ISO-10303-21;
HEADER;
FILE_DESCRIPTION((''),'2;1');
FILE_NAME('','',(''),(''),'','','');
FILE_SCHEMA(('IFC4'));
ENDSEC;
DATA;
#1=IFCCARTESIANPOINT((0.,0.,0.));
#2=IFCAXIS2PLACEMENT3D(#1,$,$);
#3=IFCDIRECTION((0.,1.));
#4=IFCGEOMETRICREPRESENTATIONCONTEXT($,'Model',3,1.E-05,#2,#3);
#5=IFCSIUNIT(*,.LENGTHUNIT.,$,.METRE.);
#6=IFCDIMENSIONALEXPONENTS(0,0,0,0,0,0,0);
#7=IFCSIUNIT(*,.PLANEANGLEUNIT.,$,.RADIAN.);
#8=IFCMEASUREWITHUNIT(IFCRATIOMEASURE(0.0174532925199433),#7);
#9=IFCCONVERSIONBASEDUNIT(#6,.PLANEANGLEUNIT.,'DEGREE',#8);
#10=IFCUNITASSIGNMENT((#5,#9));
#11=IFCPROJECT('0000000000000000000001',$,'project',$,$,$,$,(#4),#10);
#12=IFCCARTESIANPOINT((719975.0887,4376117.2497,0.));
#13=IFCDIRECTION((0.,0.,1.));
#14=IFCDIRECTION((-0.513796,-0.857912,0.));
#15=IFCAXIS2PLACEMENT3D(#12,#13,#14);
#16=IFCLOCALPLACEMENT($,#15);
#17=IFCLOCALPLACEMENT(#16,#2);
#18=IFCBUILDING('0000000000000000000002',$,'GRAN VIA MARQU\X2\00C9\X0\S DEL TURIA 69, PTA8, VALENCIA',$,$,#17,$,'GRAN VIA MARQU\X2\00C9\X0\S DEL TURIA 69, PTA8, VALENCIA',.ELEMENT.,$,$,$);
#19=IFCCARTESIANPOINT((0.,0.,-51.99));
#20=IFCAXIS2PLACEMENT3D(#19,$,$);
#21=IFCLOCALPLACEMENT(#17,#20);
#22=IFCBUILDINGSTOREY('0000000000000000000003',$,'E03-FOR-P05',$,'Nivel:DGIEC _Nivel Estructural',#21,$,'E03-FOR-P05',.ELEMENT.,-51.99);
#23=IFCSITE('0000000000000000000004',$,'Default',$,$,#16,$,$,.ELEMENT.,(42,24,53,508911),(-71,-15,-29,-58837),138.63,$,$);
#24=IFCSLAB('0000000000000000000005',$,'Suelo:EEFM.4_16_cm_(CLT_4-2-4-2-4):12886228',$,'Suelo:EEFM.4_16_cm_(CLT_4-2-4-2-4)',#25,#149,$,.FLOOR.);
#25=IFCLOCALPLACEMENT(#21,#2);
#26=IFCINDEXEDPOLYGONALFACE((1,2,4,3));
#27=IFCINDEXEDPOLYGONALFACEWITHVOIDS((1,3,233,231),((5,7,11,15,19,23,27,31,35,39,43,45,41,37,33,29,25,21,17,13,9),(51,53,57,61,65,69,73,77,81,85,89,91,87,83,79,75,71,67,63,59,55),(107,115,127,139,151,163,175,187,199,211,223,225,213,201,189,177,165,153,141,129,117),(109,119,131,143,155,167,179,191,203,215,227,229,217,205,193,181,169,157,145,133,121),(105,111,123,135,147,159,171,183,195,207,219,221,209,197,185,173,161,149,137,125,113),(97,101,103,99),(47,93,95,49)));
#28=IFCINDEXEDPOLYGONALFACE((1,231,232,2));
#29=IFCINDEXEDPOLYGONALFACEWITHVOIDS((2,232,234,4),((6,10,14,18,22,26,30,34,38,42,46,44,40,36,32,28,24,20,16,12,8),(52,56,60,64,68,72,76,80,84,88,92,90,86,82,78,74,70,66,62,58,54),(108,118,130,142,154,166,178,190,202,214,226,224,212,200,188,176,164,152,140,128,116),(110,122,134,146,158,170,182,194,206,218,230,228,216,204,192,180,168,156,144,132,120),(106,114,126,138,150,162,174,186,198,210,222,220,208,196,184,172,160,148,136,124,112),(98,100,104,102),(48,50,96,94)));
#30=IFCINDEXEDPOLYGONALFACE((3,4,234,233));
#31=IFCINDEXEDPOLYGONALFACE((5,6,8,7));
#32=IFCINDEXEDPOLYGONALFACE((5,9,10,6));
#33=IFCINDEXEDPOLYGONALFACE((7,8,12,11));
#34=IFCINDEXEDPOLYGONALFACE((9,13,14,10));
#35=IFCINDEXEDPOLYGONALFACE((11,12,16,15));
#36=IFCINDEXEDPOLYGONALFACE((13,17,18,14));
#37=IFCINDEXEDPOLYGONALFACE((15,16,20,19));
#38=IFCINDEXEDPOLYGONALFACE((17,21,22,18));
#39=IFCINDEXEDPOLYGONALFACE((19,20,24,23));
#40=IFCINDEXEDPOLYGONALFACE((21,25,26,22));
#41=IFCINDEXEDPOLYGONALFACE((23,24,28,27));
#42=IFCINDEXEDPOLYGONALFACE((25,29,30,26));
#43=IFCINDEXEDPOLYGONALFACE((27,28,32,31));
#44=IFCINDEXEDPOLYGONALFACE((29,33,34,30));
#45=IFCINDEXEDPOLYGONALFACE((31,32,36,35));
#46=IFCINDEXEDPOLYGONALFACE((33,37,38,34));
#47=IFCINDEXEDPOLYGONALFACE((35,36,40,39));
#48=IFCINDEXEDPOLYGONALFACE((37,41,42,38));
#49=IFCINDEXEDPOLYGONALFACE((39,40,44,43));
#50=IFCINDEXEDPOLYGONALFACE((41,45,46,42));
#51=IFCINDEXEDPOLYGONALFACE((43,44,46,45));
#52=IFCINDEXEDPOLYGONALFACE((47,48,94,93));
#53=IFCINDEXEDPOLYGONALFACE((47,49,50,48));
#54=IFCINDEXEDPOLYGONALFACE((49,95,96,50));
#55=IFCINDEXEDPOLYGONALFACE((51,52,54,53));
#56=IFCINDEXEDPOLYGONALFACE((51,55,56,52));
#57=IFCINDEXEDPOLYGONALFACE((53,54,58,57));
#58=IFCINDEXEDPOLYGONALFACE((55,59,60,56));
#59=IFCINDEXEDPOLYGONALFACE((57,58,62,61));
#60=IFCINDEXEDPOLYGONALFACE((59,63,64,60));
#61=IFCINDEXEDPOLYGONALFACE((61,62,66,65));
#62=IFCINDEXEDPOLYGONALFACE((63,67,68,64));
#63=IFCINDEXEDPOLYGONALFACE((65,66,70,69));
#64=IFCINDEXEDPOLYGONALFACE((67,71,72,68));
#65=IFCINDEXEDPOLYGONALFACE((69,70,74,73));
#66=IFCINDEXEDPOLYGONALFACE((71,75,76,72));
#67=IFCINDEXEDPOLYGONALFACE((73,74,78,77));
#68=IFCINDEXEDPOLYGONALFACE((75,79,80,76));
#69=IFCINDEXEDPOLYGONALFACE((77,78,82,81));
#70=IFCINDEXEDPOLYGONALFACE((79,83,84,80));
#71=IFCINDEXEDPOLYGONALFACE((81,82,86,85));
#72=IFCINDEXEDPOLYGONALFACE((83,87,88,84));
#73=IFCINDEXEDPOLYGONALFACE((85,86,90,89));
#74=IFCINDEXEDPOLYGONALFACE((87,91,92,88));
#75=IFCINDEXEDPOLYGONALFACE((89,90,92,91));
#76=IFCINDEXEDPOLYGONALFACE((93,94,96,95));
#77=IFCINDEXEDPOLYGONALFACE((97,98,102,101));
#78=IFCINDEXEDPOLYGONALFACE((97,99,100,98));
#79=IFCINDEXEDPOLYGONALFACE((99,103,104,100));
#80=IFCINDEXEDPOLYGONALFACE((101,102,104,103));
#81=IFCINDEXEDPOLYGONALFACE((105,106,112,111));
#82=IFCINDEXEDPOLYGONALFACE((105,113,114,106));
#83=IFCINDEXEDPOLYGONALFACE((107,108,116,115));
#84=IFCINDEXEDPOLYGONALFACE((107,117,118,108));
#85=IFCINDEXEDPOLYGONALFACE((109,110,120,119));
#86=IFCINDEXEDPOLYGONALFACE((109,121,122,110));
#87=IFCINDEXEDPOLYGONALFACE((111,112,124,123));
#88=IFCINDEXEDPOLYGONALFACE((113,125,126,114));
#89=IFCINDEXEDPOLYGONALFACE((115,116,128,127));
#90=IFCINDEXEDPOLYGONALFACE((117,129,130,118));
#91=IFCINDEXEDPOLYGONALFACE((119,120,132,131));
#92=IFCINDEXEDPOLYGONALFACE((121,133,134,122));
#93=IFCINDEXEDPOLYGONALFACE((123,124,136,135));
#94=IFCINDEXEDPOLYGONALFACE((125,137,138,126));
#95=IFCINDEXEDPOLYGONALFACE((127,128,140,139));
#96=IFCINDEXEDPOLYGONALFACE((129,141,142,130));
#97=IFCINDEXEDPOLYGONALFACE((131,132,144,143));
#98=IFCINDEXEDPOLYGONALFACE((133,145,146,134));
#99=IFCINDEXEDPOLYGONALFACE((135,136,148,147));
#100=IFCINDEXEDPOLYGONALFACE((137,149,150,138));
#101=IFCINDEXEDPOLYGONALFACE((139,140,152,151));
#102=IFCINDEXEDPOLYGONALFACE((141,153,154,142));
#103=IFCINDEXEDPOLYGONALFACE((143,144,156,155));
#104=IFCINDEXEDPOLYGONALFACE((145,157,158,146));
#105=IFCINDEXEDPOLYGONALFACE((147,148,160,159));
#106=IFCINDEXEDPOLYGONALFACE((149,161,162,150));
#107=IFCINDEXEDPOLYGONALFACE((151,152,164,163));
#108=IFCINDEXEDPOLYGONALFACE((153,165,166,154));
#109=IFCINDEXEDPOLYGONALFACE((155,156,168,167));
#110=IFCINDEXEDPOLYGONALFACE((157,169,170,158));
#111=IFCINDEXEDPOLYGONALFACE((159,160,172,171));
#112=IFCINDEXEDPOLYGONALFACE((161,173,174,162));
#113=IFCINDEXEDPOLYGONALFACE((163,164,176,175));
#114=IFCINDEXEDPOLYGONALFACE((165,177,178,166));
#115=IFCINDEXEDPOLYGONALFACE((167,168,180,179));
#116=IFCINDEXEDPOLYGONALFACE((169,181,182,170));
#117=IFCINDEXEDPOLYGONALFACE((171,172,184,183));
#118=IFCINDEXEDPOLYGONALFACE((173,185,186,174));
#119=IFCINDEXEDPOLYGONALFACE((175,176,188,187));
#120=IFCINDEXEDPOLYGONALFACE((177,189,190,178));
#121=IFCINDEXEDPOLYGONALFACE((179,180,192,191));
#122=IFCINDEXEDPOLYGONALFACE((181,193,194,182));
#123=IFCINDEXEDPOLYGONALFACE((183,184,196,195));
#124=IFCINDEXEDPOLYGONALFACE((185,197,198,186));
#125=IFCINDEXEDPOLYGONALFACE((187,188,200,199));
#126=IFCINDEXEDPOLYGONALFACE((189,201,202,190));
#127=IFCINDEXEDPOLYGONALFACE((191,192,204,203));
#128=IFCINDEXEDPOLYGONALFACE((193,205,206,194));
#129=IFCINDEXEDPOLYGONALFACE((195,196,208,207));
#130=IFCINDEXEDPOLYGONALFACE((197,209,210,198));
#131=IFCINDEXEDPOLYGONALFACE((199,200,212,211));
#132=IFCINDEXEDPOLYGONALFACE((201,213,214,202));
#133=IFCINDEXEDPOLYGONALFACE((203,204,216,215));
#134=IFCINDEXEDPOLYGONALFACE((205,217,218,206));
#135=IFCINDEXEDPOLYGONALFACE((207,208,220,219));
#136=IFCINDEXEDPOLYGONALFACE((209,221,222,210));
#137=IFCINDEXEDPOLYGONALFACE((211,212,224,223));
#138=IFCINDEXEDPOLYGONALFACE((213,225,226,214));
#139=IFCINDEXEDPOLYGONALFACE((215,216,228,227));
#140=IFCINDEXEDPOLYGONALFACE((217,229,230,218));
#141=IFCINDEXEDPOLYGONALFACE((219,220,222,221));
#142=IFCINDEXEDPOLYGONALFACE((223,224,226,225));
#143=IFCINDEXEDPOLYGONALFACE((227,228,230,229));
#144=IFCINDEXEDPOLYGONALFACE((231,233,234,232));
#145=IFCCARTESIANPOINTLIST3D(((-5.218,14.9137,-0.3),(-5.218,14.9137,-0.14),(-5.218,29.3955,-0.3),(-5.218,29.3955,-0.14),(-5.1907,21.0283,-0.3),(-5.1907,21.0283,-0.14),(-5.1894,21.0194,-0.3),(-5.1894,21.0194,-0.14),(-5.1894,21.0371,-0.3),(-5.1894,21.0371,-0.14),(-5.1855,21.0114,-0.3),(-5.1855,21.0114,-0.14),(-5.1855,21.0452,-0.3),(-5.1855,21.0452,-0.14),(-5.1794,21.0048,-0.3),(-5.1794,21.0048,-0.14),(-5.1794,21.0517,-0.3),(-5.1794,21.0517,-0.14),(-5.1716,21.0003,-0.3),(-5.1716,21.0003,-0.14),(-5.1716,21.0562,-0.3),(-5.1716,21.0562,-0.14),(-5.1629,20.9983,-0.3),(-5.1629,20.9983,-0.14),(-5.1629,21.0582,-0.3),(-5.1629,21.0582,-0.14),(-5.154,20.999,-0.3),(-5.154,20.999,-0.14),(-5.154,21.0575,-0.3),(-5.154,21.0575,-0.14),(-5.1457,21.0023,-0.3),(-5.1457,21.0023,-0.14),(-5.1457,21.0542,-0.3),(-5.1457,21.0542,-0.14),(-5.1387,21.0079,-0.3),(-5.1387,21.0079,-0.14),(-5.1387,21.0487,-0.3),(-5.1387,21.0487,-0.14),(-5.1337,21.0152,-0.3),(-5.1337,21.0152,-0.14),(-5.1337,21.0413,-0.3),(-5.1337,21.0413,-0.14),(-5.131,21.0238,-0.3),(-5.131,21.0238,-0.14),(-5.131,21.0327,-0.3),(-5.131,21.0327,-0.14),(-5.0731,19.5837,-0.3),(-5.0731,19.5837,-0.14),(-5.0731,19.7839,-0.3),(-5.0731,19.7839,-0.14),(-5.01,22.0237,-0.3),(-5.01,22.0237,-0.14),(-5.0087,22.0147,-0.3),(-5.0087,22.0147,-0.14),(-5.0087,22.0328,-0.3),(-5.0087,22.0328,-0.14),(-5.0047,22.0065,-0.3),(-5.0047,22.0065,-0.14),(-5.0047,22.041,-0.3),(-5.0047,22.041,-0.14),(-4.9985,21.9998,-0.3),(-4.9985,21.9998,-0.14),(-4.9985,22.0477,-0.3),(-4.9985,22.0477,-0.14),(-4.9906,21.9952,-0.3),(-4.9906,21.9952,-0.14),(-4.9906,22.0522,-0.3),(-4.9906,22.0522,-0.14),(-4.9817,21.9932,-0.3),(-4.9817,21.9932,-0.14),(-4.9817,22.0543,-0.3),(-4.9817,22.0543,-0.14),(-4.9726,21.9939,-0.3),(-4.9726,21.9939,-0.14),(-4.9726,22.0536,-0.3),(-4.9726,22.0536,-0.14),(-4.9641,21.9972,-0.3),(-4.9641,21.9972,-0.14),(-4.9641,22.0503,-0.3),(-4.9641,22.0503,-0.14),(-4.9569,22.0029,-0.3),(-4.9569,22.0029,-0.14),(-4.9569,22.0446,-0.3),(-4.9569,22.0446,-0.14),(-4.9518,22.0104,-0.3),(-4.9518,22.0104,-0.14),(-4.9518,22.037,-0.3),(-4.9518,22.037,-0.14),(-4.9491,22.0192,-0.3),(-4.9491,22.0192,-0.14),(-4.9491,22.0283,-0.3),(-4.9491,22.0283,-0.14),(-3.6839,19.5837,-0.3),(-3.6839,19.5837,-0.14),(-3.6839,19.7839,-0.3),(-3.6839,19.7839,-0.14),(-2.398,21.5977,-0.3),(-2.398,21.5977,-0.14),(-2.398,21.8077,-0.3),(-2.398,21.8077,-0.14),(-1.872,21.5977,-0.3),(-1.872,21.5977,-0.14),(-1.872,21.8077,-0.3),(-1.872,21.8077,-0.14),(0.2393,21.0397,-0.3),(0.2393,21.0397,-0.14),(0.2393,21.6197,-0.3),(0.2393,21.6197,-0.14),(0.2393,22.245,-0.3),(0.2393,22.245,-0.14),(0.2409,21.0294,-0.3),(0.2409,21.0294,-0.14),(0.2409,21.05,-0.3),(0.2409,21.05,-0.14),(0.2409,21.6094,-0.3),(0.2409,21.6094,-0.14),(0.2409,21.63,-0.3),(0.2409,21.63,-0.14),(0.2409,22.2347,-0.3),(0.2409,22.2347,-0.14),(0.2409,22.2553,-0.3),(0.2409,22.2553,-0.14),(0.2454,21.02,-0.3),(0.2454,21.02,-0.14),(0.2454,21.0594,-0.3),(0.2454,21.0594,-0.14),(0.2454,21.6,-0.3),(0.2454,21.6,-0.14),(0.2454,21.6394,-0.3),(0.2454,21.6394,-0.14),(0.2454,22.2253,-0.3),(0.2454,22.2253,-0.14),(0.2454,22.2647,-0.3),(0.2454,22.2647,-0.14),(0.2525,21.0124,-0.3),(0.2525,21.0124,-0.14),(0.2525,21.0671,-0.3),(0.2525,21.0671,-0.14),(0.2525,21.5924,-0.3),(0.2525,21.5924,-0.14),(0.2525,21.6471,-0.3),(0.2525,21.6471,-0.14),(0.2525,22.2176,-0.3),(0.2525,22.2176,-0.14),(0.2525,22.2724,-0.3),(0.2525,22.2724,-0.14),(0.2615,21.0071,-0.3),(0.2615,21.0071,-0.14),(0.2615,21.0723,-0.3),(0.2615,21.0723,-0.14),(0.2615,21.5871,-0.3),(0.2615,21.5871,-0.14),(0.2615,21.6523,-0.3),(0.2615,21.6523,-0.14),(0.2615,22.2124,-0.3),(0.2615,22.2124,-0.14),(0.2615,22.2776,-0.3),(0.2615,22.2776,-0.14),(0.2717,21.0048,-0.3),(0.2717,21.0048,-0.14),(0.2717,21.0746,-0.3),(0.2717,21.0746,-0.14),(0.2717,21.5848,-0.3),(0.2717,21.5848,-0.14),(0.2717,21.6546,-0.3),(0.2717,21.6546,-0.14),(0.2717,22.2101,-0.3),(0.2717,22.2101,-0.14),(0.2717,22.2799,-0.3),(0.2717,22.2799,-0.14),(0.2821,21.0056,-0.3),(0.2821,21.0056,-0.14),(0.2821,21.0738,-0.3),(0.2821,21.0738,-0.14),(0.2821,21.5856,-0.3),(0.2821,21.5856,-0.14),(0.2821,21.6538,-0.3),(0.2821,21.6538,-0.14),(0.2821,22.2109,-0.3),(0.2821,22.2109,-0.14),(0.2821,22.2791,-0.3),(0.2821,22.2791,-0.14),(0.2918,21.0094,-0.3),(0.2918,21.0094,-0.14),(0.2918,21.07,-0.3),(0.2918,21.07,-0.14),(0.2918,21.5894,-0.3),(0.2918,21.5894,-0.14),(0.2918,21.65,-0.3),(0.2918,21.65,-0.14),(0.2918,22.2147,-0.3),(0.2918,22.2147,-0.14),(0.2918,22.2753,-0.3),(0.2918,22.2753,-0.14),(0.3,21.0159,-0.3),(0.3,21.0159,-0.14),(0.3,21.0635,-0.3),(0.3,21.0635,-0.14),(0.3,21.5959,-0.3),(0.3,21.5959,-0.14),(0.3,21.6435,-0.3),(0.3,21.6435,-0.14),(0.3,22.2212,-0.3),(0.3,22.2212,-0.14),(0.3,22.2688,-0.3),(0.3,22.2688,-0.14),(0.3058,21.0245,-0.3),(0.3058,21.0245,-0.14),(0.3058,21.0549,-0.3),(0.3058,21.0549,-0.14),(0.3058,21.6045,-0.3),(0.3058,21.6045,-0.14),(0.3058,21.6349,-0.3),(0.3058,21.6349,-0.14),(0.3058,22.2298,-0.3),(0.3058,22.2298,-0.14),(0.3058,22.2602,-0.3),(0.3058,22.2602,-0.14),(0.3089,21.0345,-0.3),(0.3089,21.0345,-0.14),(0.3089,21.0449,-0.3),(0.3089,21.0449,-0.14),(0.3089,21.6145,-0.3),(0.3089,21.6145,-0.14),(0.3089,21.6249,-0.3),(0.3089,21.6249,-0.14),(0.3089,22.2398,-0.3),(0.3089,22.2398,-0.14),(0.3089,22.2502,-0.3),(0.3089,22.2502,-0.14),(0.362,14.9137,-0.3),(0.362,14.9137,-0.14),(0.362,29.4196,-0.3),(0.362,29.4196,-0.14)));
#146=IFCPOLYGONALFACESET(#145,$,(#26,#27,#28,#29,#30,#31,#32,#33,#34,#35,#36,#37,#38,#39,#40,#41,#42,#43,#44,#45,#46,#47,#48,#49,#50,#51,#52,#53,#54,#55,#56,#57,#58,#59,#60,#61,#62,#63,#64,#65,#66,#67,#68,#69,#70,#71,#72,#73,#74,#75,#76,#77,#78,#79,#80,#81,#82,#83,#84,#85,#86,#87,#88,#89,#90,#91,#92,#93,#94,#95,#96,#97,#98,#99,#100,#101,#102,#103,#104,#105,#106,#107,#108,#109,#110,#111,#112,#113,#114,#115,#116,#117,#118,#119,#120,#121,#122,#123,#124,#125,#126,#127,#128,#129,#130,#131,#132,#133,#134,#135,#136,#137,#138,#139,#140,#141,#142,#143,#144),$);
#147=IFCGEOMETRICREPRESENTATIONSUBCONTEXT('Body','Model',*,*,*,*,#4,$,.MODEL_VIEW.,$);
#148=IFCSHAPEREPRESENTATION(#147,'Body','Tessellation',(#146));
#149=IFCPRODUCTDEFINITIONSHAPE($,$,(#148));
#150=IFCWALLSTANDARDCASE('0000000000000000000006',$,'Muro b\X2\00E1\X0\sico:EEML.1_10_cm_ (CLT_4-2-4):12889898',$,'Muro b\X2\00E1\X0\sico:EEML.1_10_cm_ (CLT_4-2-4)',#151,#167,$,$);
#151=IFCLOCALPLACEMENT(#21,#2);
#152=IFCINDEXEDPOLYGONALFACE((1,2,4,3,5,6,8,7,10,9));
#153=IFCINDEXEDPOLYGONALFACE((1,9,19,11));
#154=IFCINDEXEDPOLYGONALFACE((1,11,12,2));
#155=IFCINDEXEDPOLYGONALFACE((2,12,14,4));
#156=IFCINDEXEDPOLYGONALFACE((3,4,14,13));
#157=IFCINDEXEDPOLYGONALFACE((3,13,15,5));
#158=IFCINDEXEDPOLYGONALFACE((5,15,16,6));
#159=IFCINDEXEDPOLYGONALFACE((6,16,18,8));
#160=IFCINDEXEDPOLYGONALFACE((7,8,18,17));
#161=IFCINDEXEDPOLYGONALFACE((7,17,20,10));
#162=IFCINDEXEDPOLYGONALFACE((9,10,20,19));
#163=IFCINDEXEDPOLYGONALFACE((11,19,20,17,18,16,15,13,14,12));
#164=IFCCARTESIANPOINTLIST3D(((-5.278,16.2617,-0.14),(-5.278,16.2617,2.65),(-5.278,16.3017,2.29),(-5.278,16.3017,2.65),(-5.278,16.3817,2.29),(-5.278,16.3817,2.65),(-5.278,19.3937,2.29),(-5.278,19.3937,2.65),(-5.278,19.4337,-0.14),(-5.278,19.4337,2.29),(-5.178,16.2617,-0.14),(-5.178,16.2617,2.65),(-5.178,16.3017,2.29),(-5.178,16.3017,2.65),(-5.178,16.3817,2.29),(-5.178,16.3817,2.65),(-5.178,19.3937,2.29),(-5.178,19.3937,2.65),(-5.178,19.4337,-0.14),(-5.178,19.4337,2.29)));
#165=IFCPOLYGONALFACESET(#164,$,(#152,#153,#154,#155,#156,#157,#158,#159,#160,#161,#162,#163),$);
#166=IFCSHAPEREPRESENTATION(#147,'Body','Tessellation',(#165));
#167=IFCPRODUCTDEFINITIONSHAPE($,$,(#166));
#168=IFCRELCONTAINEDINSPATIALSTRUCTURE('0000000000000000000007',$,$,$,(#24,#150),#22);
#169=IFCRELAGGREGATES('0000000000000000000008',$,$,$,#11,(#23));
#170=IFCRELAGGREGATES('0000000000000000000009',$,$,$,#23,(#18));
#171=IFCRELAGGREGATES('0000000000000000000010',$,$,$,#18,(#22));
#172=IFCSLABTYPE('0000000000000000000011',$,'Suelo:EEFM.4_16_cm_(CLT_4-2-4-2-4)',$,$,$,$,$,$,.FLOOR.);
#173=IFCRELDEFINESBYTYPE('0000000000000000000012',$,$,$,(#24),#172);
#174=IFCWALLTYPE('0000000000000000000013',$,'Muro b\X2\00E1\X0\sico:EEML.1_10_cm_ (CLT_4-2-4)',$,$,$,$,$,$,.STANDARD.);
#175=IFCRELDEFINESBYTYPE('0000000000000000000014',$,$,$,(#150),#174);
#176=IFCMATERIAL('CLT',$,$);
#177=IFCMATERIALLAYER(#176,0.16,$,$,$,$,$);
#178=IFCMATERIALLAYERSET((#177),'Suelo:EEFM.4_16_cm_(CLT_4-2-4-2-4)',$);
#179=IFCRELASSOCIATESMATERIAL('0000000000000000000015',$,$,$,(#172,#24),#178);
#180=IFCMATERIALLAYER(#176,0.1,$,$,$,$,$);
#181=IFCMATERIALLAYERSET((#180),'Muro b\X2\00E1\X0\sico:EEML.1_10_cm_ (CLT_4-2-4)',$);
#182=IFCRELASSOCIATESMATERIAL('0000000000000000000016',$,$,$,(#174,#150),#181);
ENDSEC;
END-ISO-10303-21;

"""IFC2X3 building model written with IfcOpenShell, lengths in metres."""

from ifc_helpers import new_model, entity, si_unit, converted_unit, direction, frame, frame_2d, origin, place, context, subcontext, project, spatial, polyline, rectangle, circle, outline, extrude, material, layer, layer_set, layer_usage, type_object, element, save


model = new_model("IFC2X3")

# Units and contexts
model_context = context("Model", 3, precision=1e-05, world=origin(), true_north=direction((0.0, 1.0)))
body_context = subcontext(model_context, "Body", "Model", "MODEL_VIEW")
ifc_project = project(units=[si_unit("LENGTHUNIT", "METRE"), converted_unit("PLANEANGLEUNIT", "DEGREE", entity("IfcRatioMeasure", 0.0174532925199433), si_unit("PLANEANGLEUNIT", "RADIAN"), dimensions=[0, 0, 0, 0, 0, 0, 0])], contexts=[model_context])

# Site, building, storey
site_placement = place(None, frame((719975.0887, 4376117.2497, 0.0), z_axis=(0.0, 0.0, 1.0), x_axis=(-0.513796, -0.857912, 0.0)))
site = spatial("IfcSite", under=ifc_project, at=site_placement, Name="Default", CompositionType="ELEMENT", RefLatitude=(42, 24, 53, 508911), RefLongitude=(-71, -15, -29, -58837), RefElevation=138.63)
building_placement = place(site_placement, origin())
building = spatial("IfcBuilding", under=site, at=building_placement, Name="GRAN VIA MARQUÉS DEL TURIA 69, PTA8, VALENCIA", LongName="GRAN VIA MARQUÉS DEL TURIA 69, PTA8, VALENCIA", CompositionType="ELEMENT")
storey_placement = place(building_placement, frame((0.0, 0.0, -51.99)))
storey = spatial("IfcBuildingStorey", under=building, at=storey_placement, Name="E03-FOR-P05", ObjectType="Nivel:DGIEC _Nivel Estructural", LongName="E03-FOR-P05", CompositionType="ELEMENT", Elevation=-51.99)

# Slab, openings
ifc_material = material(Name="CLT")
ifc_layer_1 = layer(ifc_material, 0.16)
ifc_layer_set_1 = layer_set([ifc_layer_1], Name="Suelo:EEFM.4_16_cm_(CLT_4-2-4-2-4)")
ifc_layer_usage_1 = layer_usage(ifc_layer_set_1, "AXIS3", "POSITIVE", 0.0)
slab_type_1 = type_object("IfcSlabType", Name="Suelo:EEFM.4_16_cm_(CLT_4-2-4-2-4)", PredefinedType="FLOOR", material=ifc_layer_set_1)
slab_1_placement = place(storey_placement, frame((-5.218, 14.9137, -0.3)))
slab_1 = element("IfcSlab", 1, at=slab_1_placement, inside=storey, type_object=slab_type_1, material=ifc_layer_usage_1, Name="Suelo:EEFM.4_16_cm_(CLT_4-2-4-2-4):12886228", ObjectType="Suelo:EEFM.4_16_cm_(CLT_4-2-4-2-4)", PredefinedType="FLOOR", context=body_context, shape_type="SweptSolid", body=[
    extrude(outline(polyline([(-2.79, 7.2529), (-2.79, -7.2529), (2.79, -7.2529), (2.79, 7.2288), (-2.79, 7.2529)])), frame((2.79, 7.2529, 0.16), z_axis=(0.0, 0.0, -1.0), x_axis=(-1.0, 0.0, 0.0)), (0.0, 0.0, 1.0), 0.16),
])
opening_1_placement = place(storey_placement, frame((-5.218, 14.9137, -0.3)))
element("IfcOpeningElement", 2, at=opening_1_placement, cuts=slab_1, ObjectType="Opening", context=body_context, shape_type="SweptSolid", body=[
    extrude(rectangle(XDim=0.2002, YDim=1.3893, at=frame_2d((1.9505, -2.4829), x_axis=(0.0, -1.0))), frame((2.79, 7.2529, 0.16), z_axis=(0.0, 0.0, -1.0), x_axis=(-1.0, 0.0, 0.0)), (0.0, 0.0, 1.0), 0.16),
])
opening_2_placement = place(storey_placement, frame((-5.218, 14.9137, -0.3)))
element("IfcOpeningElement", 3, at=opening_2_placement, cuts=slab_1, ObjectType="Opening", context=body_context, shape_type="SweptSolid", body=[
    extrude(rectangle(XDim=0.21, YDim=0.5259, at=frame_2d((-0.293, -0.4639), x_axis=(0.0, -1.0))), frame((2.79, 7.2529, 0.16), z_axis=(0.0, 0.0, -1.0), x_axis=(-1.0, 0.0, 0.0)), (0.0, 0.0, 1.0), 0.16),
])
opening_3_placement = place(storey_placement, frame((-5.218, 14.9137, -0.3)))
element("IfcOpeningElement", 4, at=opening_3_placement, cuts=slab_1, ObjectType="Opening", context=body_context, shape_type="SweptSolid", body=[
    extrude(circle(Radius=0.035, at=frame_2d((-2.7024, -1.1269), x_axis=(1.0, 0.0))), frame((2.79, 7.2529, 0.16), z_axis=(0.0, 0.0, -1.0), x_axis=(-1.0, 0.0, 0.0)), (0.0, 0.0, 1.0), 0.16),
])
opening_4_placement = place(storey_placement, frame((-5.218, 14.9137, -0.3)))
element("IfcOpeningElement", 5, at=opening_4_placement, cuts=slab_1, ObjectType="Opening", context=body_context, shape_type="SweptSolid", body=[
    extrude(circle(Radius=0.035, at=frame_2d((-2.7024, -0.5469), x_axis=(1.0, 0.0))), frame((2.79, 7.2529, 0.16), z_axis=(0.0, 0.0, -1.0), x_axis=(-1.0, 0.0, 0.0)), (0.0, 0.0, 1.0), 0.16),
])
opening_5_placement = place(storey_placement, frame((-5.218, 14.9137, -0.3)))
element("IfcOpeningElement", 6, at=opening_5_placement, cuts=slab_1, ObjectType="Opening", context=body_context, shape_type="SweptSolid", body=[
    extrude(circle(Radius=0.035, at=frame_2d((-2.7024, 0.0784), x_axis=(1.0, 0.0))), frame((2.79, 7.2529, 0.16), z_axis=(0.0, 0.0, -1.0), x_axis=(-1.0, 0.0, 0.0)), (0.0, 0.0, 1.0), 0.16),
])
opening_6_placement = place(storey_placement, frame((-5.218, 14.9137, -0.3)))
element("IfcOpeningElement", 7, at=opening_6_placement, cuts=slab_1, ObjectType="Opening", context=body_context, shape_type="SweptSolid", body=[
    extrude(circle(Radius=0.0306, at=frame_2d((2.5513, -0.1429), x_axis=(1.0, 0.0))), frame((2.79, 7.2529, 0.16), z_axis=(0.0, 0.0, -1.0), x_axis=(-1.0, 0.0, 0.0)), (0.0, 0.0, 1.0), 0.16),
])
opening_7_placement = place(storey_placement, frame((-5.218, 14.9137, -0.3)))
element("IfcOpeningElement", 8, at=opening_7_placement, cuts=slab_1, ObjectType="Opening", context=body_context, shape_type="SweptSolid", body=[
    extrude(circle(Radius=0.03, at=frame_2d((2.7326, -1.1384), x_axis=(1.0, 0.0))), frame((2.79, 7.2529, 0.16), z_axis=(0.0, 0.0, -1.0), x_axis=(-1.0, 0.0, 0.0)), (0.0, 0.0, 1.0), 0.16),
])

# Wall, openings
ifc_layer_2 = layer(ifc_material, 0.1)
ifc_layer_set_2 = layer_set([ifc_layer_2], Name="Muro básico:EEML.1_10_cm_ (CLT_4-2-4)")
ifc_layer_usage_2 = layer_usage(ifc_layer_set_2, "AXIS2", "NEGATIVE", 0.05)
wall_type_1 = type_object("IfcWallType", Name="Muro básico:EEML.1_10_cm_ (CLT_4-2-4)", PredefinedType="STANDARD", material=ifc_layer_set_2)
wall_1_placement = place(storey_placement, frame((-5.228, 16.2617, -0.14), z_axis=(0.0, 0.0, 1.0), x_axis=(0.0, 1.0, 0.0)))
wall_1 = element("IfcWallStandardCase", 9, at=wall_1_placement, inside=storey, type_object=wall_type_1, material=ifc_layer_usage_2, Name="Muro básico:EEML.1_10_cm_ (CLT_4-2-4):12889898", ObjectType="Muro básico:EEML.1_10_cm_ (CLT_4-2-4)", context=body_context, shape_type="SweptSolid", body=[
    extrude(rectangle(XDim=3.172, YDim=0.1, at=frame_2d((1.586, 0.0), x_axis=(-1.0, 0.0))), origin(), (0.0, 0.0, 1.0), 2.79),
])
opening_8_placement = place(wall_1_placement, origin())
element("IfcOpeningElement", 10, at=opening_8_placement, cuts=wall_1, ObjectType="Opening", context=body_context, shape_type="SweptSolid", body=[
    extrude(rectangle(XDim=0.36, YDim=0.08, at=frame_2d((0.0, 0.0), x_axis=(1.0, 0.0))), frame((3.172, 0.05, 2.61), z_axis=(0.0, -1.0, 0.0), x_axis=(0.0, 0.0, 1.0)), (0.0, 0.0, 1.0), 0.1),
])
opening_9_placement = place(wall_1_placement, origin())
element("IfcOpeningElement", 11, at=opening_9_placement, cuts=wall_1, ObjectType="Opening", context=body_context, shape_type="SweptSolid", body=[
    extrude(rectangle(XDim=0.36, YDim=0.08, at=frame_2d((0.0, 0.0), x_axis=(0.0, 1.0))), frame((0.08, 0.05, 2.61), z_axis=(0.0, -1.0, 0.0), x_axis=(-1.0, 0.0, 0.0)), (0.0, 0.0, 1.0), 0.1),
])

save(model, "model.ifc")
